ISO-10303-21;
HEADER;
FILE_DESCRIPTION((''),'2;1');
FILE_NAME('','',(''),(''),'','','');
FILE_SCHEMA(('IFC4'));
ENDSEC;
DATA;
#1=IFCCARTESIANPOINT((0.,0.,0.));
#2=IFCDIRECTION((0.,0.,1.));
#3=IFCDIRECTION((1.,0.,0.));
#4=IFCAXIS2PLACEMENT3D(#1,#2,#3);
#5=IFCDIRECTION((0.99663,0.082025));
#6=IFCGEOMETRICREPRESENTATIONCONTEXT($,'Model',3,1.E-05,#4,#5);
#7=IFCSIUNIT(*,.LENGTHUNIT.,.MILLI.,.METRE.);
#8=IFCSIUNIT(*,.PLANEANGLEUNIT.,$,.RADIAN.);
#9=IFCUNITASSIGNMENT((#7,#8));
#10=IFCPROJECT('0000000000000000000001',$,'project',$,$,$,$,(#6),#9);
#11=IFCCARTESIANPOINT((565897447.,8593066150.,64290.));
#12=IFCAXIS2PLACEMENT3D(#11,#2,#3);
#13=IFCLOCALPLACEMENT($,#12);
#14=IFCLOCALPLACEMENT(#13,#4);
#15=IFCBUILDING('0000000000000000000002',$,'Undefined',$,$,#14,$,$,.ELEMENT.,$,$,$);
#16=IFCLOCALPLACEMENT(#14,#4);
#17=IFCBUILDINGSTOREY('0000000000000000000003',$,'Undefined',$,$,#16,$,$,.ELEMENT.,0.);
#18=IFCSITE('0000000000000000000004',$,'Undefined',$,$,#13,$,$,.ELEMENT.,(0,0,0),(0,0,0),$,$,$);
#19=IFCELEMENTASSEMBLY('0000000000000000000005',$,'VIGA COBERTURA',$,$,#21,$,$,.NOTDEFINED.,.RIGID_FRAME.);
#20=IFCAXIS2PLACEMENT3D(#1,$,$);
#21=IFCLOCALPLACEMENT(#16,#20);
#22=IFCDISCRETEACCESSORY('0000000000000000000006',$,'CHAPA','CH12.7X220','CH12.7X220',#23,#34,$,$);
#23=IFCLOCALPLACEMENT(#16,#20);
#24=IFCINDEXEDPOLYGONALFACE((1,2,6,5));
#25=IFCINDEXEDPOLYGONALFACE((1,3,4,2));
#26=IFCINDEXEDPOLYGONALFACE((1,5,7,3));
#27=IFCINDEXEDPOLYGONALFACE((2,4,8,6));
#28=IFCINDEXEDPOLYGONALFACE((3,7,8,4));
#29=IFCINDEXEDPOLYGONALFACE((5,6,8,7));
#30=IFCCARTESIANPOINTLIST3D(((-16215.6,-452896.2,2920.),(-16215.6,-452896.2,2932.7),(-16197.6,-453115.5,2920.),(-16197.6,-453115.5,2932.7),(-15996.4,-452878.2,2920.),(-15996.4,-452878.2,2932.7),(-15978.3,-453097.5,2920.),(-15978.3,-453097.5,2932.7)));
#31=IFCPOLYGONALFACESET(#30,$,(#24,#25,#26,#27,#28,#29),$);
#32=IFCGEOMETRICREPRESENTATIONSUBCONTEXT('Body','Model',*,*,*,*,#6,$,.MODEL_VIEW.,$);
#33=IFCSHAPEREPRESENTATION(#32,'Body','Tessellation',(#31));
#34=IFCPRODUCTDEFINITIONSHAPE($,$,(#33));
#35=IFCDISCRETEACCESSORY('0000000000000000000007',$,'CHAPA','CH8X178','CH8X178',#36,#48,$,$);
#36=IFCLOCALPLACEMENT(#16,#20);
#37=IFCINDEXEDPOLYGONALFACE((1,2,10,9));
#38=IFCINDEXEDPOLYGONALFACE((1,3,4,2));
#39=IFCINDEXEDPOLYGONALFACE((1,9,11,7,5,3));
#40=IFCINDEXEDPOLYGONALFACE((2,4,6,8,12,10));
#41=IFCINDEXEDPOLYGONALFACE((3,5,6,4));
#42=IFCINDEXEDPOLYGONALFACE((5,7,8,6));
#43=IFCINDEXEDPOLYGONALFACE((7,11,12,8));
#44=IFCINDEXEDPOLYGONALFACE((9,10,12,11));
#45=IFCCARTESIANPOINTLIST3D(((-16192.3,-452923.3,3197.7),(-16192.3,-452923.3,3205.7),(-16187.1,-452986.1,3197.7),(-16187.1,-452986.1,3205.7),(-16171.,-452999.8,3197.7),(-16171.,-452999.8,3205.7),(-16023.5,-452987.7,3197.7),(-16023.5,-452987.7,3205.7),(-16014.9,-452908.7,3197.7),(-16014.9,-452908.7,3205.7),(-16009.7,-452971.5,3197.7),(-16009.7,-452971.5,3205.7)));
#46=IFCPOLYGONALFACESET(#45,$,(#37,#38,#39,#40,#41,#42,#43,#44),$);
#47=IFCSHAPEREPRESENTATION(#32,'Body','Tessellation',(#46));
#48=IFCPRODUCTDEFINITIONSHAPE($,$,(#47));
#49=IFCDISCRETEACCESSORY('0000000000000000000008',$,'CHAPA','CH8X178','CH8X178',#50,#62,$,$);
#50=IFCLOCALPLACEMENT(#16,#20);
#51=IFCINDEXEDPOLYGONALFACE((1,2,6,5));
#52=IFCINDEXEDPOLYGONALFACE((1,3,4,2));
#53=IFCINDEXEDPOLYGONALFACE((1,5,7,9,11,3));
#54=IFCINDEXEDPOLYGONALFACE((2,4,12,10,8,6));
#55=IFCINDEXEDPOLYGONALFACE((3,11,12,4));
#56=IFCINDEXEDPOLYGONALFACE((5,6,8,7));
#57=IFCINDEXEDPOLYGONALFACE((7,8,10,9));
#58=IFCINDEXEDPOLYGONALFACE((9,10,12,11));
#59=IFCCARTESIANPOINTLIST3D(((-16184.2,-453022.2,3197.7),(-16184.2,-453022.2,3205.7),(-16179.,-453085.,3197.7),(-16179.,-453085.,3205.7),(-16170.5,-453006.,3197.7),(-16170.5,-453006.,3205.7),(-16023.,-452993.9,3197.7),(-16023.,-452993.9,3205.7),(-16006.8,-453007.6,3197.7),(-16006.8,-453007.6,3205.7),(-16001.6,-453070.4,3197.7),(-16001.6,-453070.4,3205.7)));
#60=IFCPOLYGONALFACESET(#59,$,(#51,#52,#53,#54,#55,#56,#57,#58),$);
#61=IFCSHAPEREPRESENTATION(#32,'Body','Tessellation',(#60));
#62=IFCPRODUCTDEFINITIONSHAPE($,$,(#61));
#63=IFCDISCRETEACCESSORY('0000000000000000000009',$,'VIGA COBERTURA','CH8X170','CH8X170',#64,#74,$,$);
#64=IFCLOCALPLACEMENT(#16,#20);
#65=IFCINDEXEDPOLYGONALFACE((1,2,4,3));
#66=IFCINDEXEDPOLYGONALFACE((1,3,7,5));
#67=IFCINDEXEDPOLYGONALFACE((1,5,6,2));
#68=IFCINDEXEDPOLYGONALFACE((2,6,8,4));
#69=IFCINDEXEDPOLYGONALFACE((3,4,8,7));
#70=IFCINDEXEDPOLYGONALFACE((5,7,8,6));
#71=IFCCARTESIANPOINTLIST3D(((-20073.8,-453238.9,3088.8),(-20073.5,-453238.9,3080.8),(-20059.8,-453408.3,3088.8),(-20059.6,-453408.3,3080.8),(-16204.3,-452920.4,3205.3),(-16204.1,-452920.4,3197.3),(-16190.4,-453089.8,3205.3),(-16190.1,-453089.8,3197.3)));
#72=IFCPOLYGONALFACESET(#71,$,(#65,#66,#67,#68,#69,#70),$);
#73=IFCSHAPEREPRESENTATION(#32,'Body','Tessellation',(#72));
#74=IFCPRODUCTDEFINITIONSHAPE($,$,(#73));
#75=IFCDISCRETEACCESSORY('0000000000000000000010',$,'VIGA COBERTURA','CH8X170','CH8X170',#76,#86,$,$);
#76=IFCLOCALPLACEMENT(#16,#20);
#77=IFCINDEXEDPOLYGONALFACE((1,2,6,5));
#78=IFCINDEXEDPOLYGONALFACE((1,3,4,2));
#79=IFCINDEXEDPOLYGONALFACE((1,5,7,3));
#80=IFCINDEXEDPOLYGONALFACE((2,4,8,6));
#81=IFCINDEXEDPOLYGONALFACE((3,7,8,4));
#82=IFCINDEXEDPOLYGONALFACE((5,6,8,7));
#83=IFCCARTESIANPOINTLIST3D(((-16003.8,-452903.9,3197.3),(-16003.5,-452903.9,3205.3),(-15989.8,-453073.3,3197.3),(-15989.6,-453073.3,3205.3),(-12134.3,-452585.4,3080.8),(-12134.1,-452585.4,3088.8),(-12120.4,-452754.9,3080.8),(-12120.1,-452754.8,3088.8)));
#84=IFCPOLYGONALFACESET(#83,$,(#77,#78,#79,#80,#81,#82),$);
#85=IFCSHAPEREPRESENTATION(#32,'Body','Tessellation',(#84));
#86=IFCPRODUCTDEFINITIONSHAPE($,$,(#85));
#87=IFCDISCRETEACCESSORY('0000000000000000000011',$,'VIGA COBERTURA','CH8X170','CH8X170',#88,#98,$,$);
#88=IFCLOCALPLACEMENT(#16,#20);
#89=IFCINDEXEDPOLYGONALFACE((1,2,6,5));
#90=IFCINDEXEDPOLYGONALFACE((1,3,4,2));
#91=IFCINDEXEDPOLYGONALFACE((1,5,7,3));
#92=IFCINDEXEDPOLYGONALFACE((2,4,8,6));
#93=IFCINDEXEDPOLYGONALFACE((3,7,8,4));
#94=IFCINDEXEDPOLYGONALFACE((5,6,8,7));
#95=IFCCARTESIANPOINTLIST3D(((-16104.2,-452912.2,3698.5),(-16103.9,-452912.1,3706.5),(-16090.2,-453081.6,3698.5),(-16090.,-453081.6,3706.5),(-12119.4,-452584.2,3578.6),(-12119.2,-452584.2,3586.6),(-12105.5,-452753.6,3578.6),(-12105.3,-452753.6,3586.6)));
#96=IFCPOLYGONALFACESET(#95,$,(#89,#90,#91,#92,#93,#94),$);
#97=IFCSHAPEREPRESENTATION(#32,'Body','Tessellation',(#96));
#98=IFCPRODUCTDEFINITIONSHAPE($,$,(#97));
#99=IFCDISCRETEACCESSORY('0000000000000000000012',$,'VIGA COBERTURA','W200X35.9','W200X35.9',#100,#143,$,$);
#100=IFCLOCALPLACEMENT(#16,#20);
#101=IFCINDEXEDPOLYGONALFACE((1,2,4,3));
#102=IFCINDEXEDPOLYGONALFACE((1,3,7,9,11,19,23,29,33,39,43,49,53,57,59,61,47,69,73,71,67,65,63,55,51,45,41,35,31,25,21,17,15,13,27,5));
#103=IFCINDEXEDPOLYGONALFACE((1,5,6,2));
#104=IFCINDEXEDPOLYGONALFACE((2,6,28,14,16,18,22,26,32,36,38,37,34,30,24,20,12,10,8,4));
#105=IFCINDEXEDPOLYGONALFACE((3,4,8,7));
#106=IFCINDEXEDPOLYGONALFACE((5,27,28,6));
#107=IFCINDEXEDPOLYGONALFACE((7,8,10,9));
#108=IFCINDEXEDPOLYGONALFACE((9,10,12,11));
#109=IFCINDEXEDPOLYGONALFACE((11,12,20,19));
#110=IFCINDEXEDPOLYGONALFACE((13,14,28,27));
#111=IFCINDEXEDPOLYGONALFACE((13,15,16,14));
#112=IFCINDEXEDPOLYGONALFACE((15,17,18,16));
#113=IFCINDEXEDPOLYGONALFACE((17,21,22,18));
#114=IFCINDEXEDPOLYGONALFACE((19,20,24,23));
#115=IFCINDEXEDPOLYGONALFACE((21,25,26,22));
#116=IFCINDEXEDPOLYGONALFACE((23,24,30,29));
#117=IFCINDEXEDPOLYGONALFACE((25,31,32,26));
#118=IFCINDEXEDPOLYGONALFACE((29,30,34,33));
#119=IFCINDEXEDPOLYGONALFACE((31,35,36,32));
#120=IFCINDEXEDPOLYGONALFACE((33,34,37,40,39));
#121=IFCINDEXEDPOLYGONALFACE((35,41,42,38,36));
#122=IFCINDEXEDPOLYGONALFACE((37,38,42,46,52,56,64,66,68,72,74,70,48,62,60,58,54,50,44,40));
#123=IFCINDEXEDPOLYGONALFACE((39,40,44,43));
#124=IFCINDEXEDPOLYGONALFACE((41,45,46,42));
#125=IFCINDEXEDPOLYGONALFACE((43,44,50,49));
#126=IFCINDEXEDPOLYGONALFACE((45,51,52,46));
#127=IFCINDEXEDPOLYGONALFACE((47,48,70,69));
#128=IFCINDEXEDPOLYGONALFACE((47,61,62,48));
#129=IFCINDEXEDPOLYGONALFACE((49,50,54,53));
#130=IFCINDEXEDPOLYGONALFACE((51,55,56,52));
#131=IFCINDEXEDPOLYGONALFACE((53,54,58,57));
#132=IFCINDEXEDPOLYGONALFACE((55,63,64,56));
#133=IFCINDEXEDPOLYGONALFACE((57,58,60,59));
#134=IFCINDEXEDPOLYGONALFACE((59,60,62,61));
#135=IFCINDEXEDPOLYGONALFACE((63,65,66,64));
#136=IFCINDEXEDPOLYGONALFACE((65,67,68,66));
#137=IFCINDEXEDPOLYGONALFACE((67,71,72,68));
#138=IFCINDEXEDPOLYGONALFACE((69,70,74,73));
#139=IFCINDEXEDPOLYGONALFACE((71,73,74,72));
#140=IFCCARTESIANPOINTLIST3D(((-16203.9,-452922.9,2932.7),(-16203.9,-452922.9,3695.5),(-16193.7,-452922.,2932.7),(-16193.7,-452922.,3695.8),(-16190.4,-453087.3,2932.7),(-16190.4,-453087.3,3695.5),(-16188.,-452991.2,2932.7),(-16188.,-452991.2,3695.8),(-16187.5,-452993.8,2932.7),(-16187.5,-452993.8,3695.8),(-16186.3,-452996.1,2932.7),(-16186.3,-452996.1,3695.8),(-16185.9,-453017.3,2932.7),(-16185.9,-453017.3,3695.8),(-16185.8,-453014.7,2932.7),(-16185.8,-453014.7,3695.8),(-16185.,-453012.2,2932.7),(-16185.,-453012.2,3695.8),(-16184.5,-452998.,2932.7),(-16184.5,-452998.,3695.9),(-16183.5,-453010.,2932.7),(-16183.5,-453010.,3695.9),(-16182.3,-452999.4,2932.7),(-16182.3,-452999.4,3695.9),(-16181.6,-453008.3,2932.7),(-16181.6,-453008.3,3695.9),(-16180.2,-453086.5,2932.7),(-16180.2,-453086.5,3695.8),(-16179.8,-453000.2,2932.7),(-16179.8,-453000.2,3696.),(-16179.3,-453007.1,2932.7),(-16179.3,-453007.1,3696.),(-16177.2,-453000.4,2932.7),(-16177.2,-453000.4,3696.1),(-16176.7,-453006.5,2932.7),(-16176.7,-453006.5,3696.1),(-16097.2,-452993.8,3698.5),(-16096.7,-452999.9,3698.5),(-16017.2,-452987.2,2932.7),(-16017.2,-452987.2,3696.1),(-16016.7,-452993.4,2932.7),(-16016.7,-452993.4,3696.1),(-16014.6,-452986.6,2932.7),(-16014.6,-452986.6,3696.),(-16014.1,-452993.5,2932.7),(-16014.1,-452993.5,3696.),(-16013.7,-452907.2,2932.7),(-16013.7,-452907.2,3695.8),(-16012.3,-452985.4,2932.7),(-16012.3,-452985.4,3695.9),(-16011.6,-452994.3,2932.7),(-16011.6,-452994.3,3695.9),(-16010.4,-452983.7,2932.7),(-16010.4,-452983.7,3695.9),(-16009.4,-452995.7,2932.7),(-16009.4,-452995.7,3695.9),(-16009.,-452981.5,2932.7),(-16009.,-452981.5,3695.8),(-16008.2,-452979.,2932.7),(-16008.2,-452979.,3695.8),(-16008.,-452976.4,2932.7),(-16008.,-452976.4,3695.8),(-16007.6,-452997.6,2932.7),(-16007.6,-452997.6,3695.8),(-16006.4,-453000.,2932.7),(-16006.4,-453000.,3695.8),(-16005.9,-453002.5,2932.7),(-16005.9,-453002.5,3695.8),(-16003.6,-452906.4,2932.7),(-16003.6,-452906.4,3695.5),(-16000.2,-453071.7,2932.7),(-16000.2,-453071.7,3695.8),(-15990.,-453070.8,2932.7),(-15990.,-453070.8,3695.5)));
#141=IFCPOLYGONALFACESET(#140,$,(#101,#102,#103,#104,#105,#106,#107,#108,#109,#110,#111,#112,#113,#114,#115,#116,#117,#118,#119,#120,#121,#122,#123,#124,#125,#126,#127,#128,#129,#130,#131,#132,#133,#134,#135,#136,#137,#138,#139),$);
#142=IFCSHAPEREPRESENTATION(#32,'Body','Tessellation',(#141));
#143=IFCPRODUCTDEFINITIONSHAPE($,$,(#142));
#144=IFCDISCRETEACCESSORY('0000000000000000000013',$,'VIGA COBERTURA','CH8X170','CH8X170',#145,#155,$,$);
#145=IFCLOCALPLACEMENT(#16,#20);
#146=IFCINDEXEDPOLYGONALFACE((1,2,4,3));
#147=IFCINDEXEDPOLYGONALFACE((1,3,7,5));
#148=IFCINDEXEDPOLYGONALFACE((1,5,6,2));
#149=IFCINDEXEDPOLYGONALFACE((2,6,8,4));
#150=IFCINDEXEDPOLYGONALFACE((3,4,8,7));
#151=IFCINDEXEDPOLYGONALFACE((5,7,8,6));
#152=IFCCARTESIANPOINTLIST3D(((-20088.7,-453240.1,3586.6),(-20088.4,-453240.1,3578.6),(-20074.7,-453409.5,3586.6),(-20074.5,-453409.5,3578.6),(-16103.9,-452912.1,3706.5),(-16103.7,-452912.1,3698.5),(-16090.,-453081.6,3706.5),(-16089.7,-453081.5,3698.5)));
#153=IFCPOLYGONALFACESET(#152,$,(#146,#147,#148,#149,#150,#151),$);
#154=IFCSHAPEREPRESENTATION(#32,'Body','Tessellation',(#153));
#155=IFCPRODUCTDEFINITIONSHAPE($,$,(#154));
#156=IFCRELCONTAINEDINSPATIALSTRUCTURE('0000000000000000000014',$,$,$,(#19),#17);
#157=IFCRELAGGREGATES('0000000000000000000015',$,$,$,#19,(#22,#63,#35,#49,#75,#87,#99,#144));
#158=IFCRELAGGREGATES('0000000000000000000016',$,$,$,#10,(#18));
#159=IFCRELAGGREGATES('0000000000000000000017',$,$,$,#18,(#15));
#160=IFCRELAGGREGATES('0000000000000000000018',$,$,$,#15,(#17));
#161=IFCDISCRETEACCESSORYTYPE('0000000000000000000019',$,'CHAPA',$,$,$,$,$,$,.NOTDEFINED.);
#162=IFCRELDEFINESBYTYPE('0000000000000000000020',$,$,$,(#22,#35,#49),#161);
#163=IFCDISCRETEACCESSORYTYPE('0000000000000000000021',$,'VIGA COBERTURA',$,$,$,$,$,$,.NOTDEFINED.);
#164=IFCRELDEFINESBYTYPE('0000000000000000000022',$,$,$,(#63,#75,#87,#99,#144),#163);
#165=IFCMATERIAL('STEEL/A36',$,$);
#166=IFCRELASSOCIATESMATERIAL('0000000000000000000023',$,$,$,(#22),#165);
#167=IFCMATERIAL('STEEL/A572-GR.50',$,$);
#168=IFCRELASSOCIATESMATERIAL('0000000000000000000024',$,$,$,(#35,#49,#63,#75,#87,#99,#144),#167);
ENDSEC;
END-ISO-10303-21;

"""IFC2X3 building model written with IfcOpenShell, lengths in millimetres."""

from ifc_helpers import new_model, si_unit, direction, frame, origin_with_axes, origin_2d_with_axis, place, context, subcontext, project, spatial, polyline, i_section, outline, extrude, clip, halfspace, material, type_object, element, aggregate, save


model = new_model("IFC2X3")

# Units and contexts
model_context = context("Model", 3, precision=1e-05, world=origin_with_axes(), true_north=direction((0.99663, 0.082025)))
body_context = subcontext(model_context, "Body", "Model", "MODEL_VIEW")
ifc_project = project(units=[si_unit("LENGTHUNIT", "METRE", prefix="MILLI"), si_unit("PLANEANGLEUNIT", "RADIAN")], contexts=[model_context])

# Site, building, storey
site_placement = place(None, frame((565897447.0, 8593066150.0, 64290.0), z_axis=(0.0, 0.0, 1.0), x_axis=(1.0, 0.0, 0.0)))
site = spatial("IfcSite", under=ifc_project, at=site_placement, Name="Undefined", CompositionType="ELEMENT", RefLatitude=(0, 0, 0), RefLongitude=(0, 0, 0))
building_placement = place(site_placement, origin_with_axes())
building = spatial("IfcBuilding", under=site, at=building_placement, Name="Undefined", CompositionType="ELEMENT")
storey_placement = place(building_placement, origin_with_axes())
storey = spatial("IfcBuildingStorey", under=building, at=storey_placement, Name="Undefined", CompositionType="ELEMENT", Elevation=0.0)

# Element assembly, discrete accessories
assembly_1_placement = place(storey_placement, origin_with_axes())
assembly_1 = element("IfcElementAssembly", 1, at=assembly_1_placement, inside=storey, Name="VIGA COBERTURA", AssemblyPlace="NOTDEFINED", PredefinedType="RIGID_FRAME")
ifc_material_1 = material(Name="STEEL/A36")
discrete_accessory_type_1 = type_object("IfcDiscreteAccessoryType", Name="CHAPA")
discrete_accessory_1_placement = place(assembly_1_placement, frame((-15987.3, -452987.8, 2926.3), z_axis=(0.0, 0.0, -1.0), x_axis=(-0.99663, -0.082025, 0.0)))
discrete_accessory_1 = element("IfcDiscreteAccessory", 2, at=discrete_accessory_1_placement, type_object=discrete_accessory_type_1, material=ifc_material_1, Name="CHAPA", Description="CH12.7X220", ObjectType="CH12.7X220", context=body_context, shape_type="SweptSolid", body=[
    extrude(outline(polyline([(220.0, 110.0), (220.0, -110.0), (0.0, -110.0), (0.0, 110.0), (220.0, 110.0)])), frame((0.0, 0.0, -6.3), z_axis=(0.0, 0.0, 1.0), x_axis=(1.0, 0.0, 0.0)), (0.0, 0.0, 1.0), 12.7),
])
ifc_material_2 = material(Name="STEEL/A572-GR.50")
discrete_accessory_2_placement = place(assembly_1_placement, frame((-16185.9, -453001.1, 3201.7), z_axis=(0.0, 0.0, -1.0), x_axis=(-0.082025, 0.99663, 0.0)))
discrete_accessory_2 = element("IfcDiscreteAccessory", 3, at=discrete_accessory_2_placement, type_object=discrete_accessory_type_1, material=ifc_material_2, Name="CHAPA", Description="CH8X178", ObjectType="CH8X178", context=body_context, shape_type="SweptSolid", body=[
    extrude(outline(polyline([(0.0, 15.0), (15.0, 0.0), (78.0, 0.0), (78.0, 178.0), (15.0, 178.0), (0.0, 163.0), (0.0, 15.0)])), frame((0.0, 0.0, -4.0), z_axis=(0.0, 0.0, 1.0), x_axis=(1.0, 0.0, 0.0)), (0.0, 0.0, 1.0), 8.0),
])
discrete_accessory_3_placement = place(assembly_1_placement, frame((-16185.4, -453007.2, 3201.7), z_axis=(0.0, 0.0, 1.0), x_axis=(0.082025, -0.99663, 0.0)))
discrete_accessory_3 = element("IfcDiscreteAccessory", 4, at=discrete_accessory_3_placement, type_object=discrete_accessory_type_1, material=ifc_material_2, Name="CHAPA", Description="CH8X178", ObjectType="CH8X178", context=body_context, shape_type="SweptSolid", body=[
    extrude(outline(polyline([(0.0, 15.0), (15.0, 0.0), (78.0, 0.0), (78.0, 178.0), (15.0, 178.0), (0.0, 163.0), (0.0, 15.0)])), frame((0.0, 0.0, -4.0), z_axis=(0.0, 0.0, 1.0), x_axis=(1.0, 0.0, 0.0)), (0.0, 0.0, 1.0), 8.0),
])
discrete_accessory_type_2 = type_object("IfcDiscreteAccessoryType", Name="VIGA COBERTURA")
discrete_accessory_4_placement = place(assembly_1_placement, frame((-16197.2, -453005.1, 3201.3), z_axis=(0.029885, 0.00246, -0.99955), x_axis=(-0.996182, -0.081989, -0.029987)))
discrete_accessory_4 = element("IfcDiscreteAccessory", 5, at=discrete_accessory_4_placement, type_object=discrete_accessory_type_2, material=ifc_material_2, Name="VIGA COBERTURA", Description="CH8X170", ObjectType="CH8X170", context=body_context, shape_type="SweptSolid", body=[
    extrude(outline(polyline([(3884.3, 85.0), (3884.3, -85.0), (0.0, -85.0), (0.0, 85.0), (3884.3, 85.0)])), frame((0.0, 0.0, -4.0), z_axis=(0.0, 0.0, 1.0), x_axis=(1.0, 0.0, 0.0)), (0.0, 0.0, 1.0), 8.0),
])
discrete_accessory_5_placement = place(assembly_1_placement, frame((-15996.7, -452988.6, 3201.3), z_axis=(-0.029885, -0.00246, -0.99955), x_axis=(0.996182, 0.081989, -0.029987)))
discrete_accessory_5 = element("IfcDiscreteAccessory", 6, at=discrete_accessory_5_placement, type_object=discrete_accessory_type_2, material=ifc_material_2, Name="VIGA COBERTURA", Description="CH8X170", ObjectType="CH8X170", context=body_context, shape_type="SweptSolid", body=[
    extrude(outline(polyline([(0.0, -85.0), (0.0, 85.0), (3884.3, 85.0), (3884.3, -85.0), (0.0, -85.0)])), frame((0.0, 0.0, -4.0), z_axis=(0.0, 0.0, 1.0), x_axis=(1.0, 0.0, 0.0)), (0.0, 0.0, 1.0), 8.0),
])
discrete_accessory_6_placement = place(assembly_1_placement, frame((-16097.1, -452996.9, 3702.5), z_axis=(-0.029885, -0.00246, -0.99955), x_axis=(0.996182, 0.081989, -0.029987)))
discrete_accessory_6 = element("IfcDiscreteAccessory", 7, at=discrete_accessory_6_placement, type_object=discrete_accessory_type_2, material=ifc_material_2, Name="VIGA COBERTURA", Description="CH8X170", ObjectType="CH8X170", context=body_context, shape_type="SweptSolid", body=[
    extrude(outline(polyline([(0.0, -85.0), (0.0, 85.0), (4000.0, 85.0), (4000.0, -85.0), (0.0, -85.0)])), frame((0.0, 0.0, -4.0), z_axis=(0.0, 0.0, 1.0), x_axis=(1.0, 0.0, 0.0)), (0.0, 0.0, 1.0), 8.0),
])
discrete_accessory_7_placement = place(assembly_1_placement, frame((-16097.0, -452996.9, 2932.7), z_axis=(0.0, 0.0, 1.0), x_axis=(0.99663, 0.082025, 0.0)))
discrete_accessory_7 = element("IfcDiscreteAccessory", 8, at=discrete_accessory_7_placement, type_object=discrete_accessory_type_2, material=ifc_material_2, Name="VIGA COBERTURA", Description="W200X35.9", ObjectType="W200X35.9", context=body_context, shape_type="Clipping", body=[
    clip(clip(clip(extrude(i_section(OverallWidth=165.0, OverallDepth=201.0, WebThickness=6.2, FlangeThickness=10.2, FilletRadius=10.0, at=origin_2d_with_axis()), frame((0.0, 0.0, 765.8), z_axis=(0.0, 0.0, -1.0), x_axis=(0.0, 1.0, 0.0)), (0.0, 0.0, 1.0), 765.8), halfspace(frame((100.5, -82.5, 768.8), z_axis=(-0.029959, 0.0, 0.999551), x_axis=(-0.999551, 0.0, -0.029959)), False)), halfspace(frame((100.5, 82.5, 768.8), z_axis=(-0.029959, 0.0, 0.999551), x_axis=(0.0, -1.0, 0.0)), False)), halfspace(frame((-100.5, 82.5, 768.8), z_axis=(0.029959, 0.0, 0.999551), x_axis=(0.999551, 0.0, -0.029959)), False)),
])
discrete_accessory_8_placement = place(assembly_1_placement, frame((-16096.8, -452996.8, 3702.5), z_axis=(0.029885, 0.00246, -0.99955), x_axis=(-0.996182, -0.081989, -0.029987)))
discrete_accessory_8 = element("IfcDiscreteAccessory", 9, at=discrete_accessory_8_placement, type_object=discrete_accessory_type_2, material=ifc_material_2, Name="VIGA COBERTURA", Description="CH8X170", ObjectType="CH8X170", context=body_context, shape_type="SweptSolid", body=[
    extrude(outline(polyline([(4000.0, 85.0), (4000.0, -85.0), (0.0, -85.0), (0.0, 85.0), (4000.0, 85.0)])), frame((0.0, 0.0, -4.0), z_axis=(0.0, 0.0, 1.0), x_axis=(1.0, 0.0, 0.0)), (0.0, 0.0, 1.0), 8.0),
])
aggregate(assembly_1, [discrete_accessory_1, discrete_accessory_4, discrete_accessory_2, discrete_accessory_3, discrete_accessory_5, discrete_accessory_6, discrete_accessory_7, discrete_accessory_8])

save(model, "model.ifc")
